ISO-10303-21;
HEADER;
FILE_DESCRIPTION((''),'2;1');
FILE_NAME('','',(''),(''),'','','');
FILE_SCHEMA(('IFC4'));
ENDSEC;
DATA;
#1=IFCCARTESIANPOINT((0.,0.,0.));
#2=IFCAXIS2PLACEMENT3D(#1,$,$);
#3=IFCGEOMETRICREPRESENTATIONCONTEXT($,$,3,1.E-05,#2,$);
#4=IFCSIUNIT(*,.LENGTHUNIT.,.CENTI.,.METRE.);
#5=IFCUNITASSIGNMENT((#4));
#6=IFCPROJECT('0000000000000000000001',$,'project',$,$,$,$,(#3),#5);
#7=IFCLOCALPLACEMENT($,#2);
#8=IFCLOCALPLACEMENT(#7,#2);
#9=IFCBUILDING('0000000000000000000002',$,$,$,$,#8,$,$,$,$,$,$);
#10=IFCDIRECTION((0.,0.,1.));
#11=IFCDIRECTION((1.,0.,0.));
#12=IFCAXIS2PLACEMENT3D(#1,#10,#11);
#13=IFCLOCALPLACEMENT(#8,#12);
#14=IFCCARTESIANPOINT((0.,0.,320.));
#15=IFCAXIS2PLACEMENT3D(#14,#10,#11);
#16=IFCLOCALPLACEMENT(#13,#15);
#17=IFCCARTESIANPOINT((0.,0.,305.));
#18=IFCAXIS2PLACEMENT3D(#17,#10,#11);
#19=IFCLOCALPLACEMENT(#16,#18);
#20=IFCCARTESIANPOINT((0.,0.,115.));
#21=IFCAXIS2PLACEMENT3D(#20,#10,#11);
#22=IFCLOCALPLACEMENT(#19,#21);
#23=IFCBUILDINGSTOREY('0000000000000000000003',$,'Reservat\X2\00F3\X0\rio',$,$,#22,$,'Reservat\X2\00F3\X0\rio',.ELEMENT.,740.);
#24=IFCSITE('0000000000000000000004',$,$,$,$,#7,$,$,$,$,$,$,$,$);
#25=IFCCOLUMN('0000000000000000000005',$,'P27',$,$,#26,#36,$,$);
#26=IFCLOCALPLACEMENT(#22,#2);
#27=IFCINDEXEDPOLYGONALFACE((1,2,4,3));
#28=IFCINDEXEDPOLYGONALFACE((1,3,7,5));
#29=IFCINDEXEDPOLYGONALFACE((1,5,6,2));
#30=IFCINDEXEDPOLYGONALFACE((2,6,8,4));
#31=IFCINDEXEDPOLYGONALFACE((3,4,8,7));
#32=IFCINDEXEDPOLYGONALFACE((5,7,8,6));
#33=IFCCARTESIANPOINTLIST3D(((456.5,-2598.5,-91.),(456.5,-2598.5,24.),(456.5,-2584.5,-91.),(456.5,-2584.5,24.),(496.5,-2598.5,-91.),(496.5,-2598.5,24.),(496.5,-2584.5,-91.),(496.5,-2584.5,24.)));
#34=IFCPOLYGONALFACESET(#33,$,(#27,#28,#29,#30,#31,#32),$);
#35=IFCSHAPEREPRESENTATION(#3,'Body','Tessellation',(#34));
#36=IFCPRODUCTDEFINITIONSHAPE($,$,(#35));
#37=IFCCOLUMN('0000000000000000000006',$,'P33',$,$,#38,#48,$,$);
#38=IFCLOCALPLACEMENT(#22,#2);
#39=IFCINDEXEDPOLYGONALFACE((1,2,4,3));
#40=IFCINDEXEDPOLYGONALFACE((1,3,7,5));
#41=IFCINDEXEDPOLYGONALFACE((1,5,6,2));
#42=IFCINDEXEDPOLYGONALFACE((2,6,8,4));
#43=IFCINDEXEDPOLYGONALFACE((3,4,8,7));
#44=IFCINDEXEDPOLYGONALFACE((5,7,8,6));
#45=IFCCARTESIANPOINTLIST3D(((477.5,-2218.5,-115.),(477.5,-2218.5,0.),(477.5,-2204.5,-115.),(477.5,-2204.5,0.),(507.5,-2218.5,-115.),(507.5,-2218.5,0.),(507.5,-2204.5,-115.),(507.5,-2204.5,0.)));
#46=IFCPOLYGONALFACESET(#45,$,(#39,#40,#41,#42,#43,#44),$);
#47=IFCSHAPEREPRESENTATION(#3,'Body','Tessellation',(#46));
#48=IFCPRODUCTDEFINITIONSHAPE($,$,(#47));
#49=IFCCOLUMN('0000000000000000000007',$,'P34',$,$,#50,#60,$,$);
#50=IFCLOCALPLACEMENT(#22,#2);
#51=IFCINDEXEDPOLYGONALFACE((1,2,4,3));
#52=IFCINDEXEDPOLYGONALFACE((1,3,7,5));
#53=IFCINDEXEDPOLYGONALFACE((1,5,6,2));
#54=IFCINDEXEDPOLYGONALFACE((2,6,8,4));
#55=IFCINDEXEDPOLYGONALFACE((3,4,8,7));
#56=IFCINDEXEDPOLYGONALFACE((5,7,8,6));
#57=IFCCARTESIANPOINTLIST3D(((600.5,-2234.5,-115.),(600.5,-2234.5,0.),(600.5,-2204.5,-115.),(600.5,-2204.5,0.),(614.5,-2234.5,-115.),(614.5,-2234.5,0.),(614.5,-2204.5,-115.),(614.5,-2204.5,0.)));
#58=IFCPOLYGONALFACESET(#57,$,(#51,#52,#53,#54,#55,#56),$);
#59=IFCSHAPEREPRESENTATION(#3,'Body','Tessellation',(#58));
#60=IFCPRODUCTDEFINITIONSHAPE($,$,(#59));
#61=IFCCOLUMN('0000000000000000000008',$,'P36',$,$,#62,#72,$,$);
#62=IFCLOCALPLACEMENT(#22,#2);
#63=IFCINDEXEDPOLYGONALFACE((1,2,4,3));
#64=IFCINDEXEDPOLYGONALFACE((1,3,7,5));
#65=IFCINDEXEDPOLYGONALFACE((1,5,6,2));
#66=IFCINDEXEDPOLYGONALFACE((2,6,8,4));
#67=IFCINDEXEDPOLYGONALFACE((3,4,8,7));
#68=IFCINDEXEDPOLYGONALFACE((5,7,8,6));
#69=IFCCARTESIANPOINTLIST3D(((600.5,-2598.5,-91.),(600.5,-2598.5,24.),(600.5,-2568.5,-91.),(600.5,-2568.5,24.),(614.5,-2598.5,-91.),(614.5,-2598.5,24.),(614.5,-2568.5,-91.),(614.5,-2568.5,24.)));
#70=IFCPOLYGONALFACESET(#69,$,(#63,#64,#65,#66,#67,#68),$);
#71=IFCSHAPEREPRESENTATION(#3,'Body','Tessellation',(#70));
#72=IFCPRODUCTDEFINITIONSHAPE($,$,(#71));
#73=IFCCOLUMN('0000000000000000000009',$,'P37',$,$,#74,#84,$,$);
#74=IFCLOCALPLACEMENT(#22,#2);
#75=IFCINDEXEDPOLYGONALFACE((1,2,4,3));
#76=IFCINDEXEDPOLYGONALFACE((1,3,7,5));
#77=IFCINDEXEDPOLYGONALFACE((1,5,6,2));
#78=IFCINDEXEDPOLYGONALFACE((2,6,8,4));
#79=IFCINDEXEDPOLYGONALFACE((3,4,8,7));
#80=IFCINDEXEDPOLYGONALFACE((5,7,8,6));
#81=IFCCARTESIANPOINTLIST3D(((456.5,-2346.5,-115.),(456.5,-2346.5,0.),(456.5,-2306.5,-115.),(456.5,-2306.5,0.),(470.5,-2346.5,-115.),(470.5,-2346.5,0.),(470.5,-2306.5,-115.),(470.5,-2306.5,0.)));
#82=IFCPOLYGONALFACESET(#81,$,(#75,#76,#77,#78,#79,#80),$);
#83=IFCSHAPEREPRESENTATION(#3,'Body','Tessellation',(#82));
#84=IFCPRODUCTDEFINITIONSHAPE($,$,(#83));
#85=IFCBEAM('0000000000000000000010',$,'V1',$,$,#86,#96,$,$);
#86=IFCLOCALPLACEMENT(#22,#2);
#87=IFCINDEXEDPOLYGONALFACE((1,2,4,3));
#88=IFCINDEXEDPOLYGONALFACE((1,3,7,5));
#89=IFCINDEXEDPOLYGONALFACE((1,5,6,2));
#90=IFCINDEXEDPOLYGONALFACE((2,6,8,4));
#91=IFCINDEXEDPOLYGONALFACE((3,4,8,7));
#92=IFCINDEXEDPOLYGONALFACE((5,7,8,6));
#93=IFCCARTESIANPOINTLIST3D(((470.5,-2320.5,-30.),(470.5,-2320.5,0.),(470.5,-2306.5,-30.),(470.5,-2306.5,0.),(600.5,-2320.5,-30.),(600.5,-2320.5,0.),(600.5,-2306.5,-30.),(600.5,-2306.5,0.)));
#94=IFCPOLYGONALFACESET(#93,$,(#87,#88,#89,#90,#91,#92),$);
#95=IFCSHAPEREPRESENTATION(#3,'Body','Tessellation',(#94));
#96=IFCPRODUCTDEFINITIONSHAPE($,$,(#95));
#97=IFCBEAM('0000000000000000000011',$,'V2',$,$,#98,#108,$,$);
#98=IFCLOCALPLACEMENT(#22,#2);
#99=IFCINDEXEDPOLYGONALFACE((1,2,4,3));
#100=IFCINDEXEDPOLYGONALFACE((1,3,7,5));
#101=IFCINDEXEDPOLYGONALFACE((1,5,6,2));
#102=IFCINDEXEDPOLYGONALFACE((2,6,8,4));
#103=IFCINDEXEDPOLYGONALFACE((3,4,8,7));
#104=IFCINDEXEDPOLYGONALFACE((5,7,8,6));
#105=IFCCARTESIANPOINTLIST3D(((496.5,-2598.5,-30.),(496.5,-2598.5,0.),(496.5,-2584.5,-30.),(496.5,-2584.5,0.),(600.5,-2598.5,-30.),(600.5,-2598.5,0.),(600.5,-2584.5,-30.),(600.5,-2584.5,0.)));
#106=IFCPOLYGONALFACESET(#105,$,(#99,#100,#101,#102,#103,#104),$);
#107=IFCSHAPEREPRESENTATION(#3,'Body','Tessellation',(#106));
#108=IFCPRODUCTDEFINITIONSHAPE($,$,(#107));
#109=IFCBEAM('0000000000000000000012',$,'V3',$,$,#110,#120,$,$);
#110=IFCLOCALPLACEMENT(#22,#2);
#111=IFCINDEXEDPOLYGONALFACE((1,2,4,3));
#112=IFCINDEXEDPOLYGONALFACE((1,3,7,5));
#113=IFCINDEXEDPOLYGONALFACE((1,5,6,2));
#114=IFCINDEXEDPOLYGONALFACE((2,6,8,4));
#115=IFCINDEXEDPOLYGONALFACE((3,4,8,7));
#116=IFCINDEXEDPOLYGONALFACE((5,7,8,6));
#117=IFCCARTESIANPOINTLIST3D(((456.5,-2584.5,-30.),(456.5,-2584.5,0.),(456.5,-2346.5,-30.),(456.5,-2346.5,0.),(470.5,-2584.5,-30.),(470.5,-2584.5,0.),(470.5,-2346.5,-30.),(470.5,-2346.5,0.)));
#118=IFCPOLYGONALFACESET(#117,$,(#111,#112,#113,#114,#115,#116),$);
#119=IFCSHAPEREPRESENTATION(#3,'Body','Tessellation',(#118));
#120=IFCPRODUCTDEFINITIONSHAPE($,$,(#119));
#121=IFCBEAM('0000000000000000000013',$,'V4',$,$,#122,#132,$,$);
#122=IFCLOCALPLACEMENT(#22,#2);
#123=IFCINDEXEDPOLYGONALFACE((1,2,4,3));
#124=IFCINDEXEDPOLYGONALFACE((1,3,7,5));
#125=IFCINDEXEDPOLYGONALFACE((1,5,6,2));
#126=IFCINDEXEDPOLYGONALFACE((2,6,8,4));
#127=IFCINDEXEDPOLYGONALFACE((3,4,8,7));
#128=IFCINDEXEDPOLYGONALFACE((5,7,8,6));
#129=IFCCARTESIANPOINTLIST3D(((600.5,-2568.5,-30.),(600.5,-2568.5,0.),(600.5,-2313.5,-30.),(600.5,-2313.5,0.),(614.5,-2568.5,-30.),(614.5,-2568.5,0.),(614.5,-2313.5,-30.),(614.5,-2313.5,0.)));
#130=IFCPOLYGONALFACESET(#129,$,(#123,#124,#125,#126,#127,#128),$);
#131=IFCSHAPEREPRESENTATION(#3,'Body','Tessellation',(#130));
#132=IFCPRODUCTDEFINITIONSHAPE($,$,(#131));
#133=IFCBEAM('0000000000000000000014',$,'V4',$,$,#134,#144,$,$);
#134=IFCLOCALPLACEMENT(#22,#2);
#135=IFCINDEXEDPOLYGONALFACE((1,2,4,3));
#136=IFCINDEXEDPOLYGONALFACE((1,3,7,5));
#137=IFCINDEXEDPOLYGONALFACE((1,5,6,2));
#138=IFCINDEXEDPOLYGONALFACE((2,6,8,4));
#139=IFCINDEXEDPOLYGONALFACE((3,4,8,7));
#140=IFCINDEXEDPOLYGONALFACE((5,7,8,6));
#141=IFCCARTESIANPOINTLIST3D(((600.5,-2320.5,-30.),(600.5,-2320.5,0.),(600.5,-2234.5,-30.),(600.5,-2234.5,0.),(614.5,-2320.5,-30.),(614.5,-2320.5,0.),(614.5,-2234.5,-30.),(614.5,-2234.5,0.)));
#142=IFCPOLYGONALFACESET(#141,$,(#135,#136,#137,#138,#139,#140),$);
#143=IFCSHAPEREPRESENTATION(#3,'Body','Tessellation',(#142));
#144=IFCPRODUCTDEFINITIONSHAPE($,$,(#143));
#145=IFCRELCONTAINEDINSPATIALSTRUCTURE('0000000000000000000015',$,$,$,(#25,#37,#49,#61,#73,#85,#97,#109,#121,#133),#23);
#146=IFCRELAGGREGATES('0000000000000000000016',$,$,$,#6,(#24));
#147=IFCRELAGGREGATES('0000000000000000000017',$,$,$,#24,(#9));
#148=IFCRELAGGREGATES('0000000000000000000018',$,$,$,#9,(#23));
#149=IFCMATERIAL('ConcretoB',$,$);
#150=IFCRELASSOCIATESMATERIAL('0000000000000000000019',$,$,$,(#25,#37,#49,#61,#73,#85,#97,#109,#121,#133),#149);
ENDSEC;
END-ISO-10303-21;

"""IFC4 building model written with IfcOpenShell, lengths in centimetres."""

from ifc_helpers import new_model, si_unit, frame, origin, origin_with_axes, place, context, project, spatial, polyline, outline, extrude, material, element, save


model = new_model("IFC4")

# Units and contexts
context_of_model = context(None, 3, precision=1e-05, world=origin())
ifc_project = project(units=[si_unit("LENGTHUNIT", "METRE", prefix="CENTI")], contexts=[context_of_model])

# Site, building, storey
site_placement = place(None, origin())
site = spatial("IfcSite", under=ifc_project, at=site_placement)
building_placement = place(site_placement, origin())
building = spatial("IfcBuilding", under=site, at=building_placement)
placement_1 = place(building_placement, origin_with_axes())
placement_2 = place(placement_1, frame((0.0, 0.0, 320.0), z_axis=(0.0, 0.0, 1.0), x_axis=(1.0, 0.0, 0.0)))
placement_3 = place(placement_2, frame((0.0, 0.0, 305.0), z_axis=(0.0, 0.0, 1.0), x_axis=(1.0, 0.0, 0.0)))
storey_placement = place(placement_3, frame((0.0, 0.0, 115.0), z_axis=(0.0, 0.0, 1.0), x_axis=(1.0, 0.0, 0.0)))
storey = spatial("IfcBuildingStorey", under=building, at=storey_placement, Name="Reservatório", LongName="Reservatório", CompositionType="ELEMENT", Elevation=740.0)

# Columns
ifc_material = material(Name="ConcretoB")
column_1_placement = place(storey_placement, frame((476.5, -2591.5, 24.0), z_axis=(0.0, 0.0, 1.0), x_axis=(1.0, 0.0, 0.0)))
element("IfcColumn", 1, at=column_1_placement, inside=storey, material=ifc_material, Name="P27", context=context_of_model, shape_type="SolidModel", body=[
    extrude(outline(polyline([(20.0, -7.0), (20.0, 7.0), (-20.0, 7.0), (-20.0, -7.0), (20.0, -7.0)])), origin_with_axes(), (0.0, 0.0, -1.0), 115.0),
])
column_2_placement = place(storey_placement, frame((492.5, -2211.5, 0.0), z_axis=(0.0, 0.0, 1.0), x_axis=(1.0, 0.0, 0.0)))
element("IfcColumn", 2, at=column_2_placement, inside=storey, material=ifc_material, Name="P33", context=context_of_model, shape_type="SolidModel", body=[
    extrude(outline(polyline([(15.0, -7.0), (15.0, 7.0), (-15.0, 7.0), (-15.0, -7.0), (15.0, -7.0)])), origin_with_axes(), (0.0, 0.0, -1.0), 115.0),
])
for number, where, z_axis, x_axis, name in (
    (3, (607.5, -2219.5, 0.0), (0.0, 0.0, 1.0), (1.0, 0.0, 0.0), "P34"),
    (4, (607.5, -2583.5, 24.0), (0.0, 0.0, 1.0), (1.0, 0.0, 0.0), "P36"),
):
    element("IfcColumn", number, at=place(storey_placement, frame(where, z_axis=z_axis, x_axis=x_axis)), inside=storey, material=ifc_material, Name=name, context=context_of_model, shape_type="SolidModel", body=[
        extrude(outline(polyline([(7.0, 15.0), (-7.0, 15.0), (-7.0, -15.0), (7.0, -15.0), (7.0, 15.0)])), origin_with_axes(), (0.0, 0.0, -1.0), 115.0),
    ])
column_3_placement = place(storey_placement, frame((463.5, -2326.5, 0.0), z_axis=(0.0, 0.0, 1.0), x_axis=(1.0, 0.0, 0.0)))
element("IfcColumn", 5, at=column_3_placement, inside=storey, material=ifc_material, Name="P37", context=context_of_model, shape_type="SolidModel", body=[
    extrude(outline(polyline([(-7.0, -20.0), (7.0, -20.0), (7.0, 20.0), (-7.0, 20.0), (-7.0, -20.0)])), origin_with_axes(), (0.0, 0.0, -1.0), 115.0),
])

# Beams
beam_1_placement = place(storey_placement, frame((535.5, -2313.5, 0.0), z_axis=(0.0, 0.0, 1.0), x_axis=(1.0, 0.0, 0.0)))
element("IfcBeam", 6, at=beam_1_placement, inside=storey, material=ifc_material, Name="V1", context=context_of_model, shape_type="SolidModel", body=[
    extrude(outline(polyline([(-7.0, -15.0), (7.0, -15.0), (7.0, 15.0), (-7.0, 15.0), (-7.0, -15.0)])), frame((-65.0, 0.0, -15.0), z_axis=(1.0, 0.0, 0.0), x_axis=(0.0, -1.0, 0.0)), (0.0, 0.0, 1.0), 130.0),
])
beam_2_placement = place(storey_placement, frame((548.5, -2591.5, 0.0), z_axis=(0.0, 0.0, 1.0), x_axis=(1.0, 0.0, 0.0)))
element("IfcBeam", 7, at=beam_2_placement, inside=storey, material=ifc_material, Name="V2", context=context_of_model, shape_type="SolidModel", body=[
    extrude(outline(polyline([(-7.0, -15.0), (7.0, -15.0), (7.0, 15.0), (-7.0, 15.0), (-7.0, -15.0)])), frame((-52.0, 0.0, -15.0), z_axis=(1.0, 0.0, 0.0), x_axis=(0.0, -1.0, 0.0)), (0.0, 0.0, 1.0), 104.0),
])
beam_3_placement = place(storey_placement, frame((463.5, -2465.5, 0.0), z_axis=(0.0, 0.0, 1.0), x_axis=(1.0, 0.0, 0.0)))
element("IfcBeam", 8, at=beam_3_placement, inside=storey, material=ifc_material, Name="V3", context=context_of_model, shape_type="SolidModel", body=[
    extrude(outline(polyline([(-7.0, -15.0), (7.0, -15.0), (7.0, 15.0), (-7.0, 15.0), (-7.0, -15.0)])), frame((0.0, -119.0, -15.0), z_axis=(0.0, 1.0, 0.0), x_axis=(1.0, 0.0, 0.0)), (0.0, 0.0, 1.0), 238.0),
])
beam_4_placement = place(storey_placement, frame((607.5, -2441.0, 0.0), z_axis=(0.0, 0.0, 1.0), x_axis=(1.0, 0.0, 0.0)))
element("IfcBeam", 9, at=beam_4_placement, inside=storey, material=ifc_material, Name="V4", context=context_of_model, shape_type="SolidModel", body=[
    extrude(outline(polyline([(-7.0, -15.0), (7.0, -15.0), (7.0, 15.0), (-7.0, 15.0), (-7.0, -15.0)])), frame((0.0, -127.5, -15.0), z_axis=(0.0, 1.0, 0.0), x_axis=(1.0, 0.0, 0.0)), (0.0, 0.0, 1.0), 255.0),
])
beam_5_placement = place(storey_placement, frame((607.5, -2277.5, 0.0), z_axis=(0.0, 0.0, 1.0), x_axis=(1.0, 0.0, 0.0)))
element("IfcBeam", 10, at=beam_5_placement, inside=storey, material=ifc_material, Name="V4", context=context_of_model, shape_type="SolidModel", body=[
    extrude(outline(polyline([(-7.0, -15.0), (7.0, -15.0), (7.0, 15.0), (-7.0, 15.0), (-7.0, -15.0)])), frame((0.0, -43.0, -15.0), z_axis=(0.0, 1.0, 0.0), x_axis=(1.0, 0.0, 0.0)), (0.0, 0.0, 1.0), 86.0),
])

save(model, "model.ifc")
